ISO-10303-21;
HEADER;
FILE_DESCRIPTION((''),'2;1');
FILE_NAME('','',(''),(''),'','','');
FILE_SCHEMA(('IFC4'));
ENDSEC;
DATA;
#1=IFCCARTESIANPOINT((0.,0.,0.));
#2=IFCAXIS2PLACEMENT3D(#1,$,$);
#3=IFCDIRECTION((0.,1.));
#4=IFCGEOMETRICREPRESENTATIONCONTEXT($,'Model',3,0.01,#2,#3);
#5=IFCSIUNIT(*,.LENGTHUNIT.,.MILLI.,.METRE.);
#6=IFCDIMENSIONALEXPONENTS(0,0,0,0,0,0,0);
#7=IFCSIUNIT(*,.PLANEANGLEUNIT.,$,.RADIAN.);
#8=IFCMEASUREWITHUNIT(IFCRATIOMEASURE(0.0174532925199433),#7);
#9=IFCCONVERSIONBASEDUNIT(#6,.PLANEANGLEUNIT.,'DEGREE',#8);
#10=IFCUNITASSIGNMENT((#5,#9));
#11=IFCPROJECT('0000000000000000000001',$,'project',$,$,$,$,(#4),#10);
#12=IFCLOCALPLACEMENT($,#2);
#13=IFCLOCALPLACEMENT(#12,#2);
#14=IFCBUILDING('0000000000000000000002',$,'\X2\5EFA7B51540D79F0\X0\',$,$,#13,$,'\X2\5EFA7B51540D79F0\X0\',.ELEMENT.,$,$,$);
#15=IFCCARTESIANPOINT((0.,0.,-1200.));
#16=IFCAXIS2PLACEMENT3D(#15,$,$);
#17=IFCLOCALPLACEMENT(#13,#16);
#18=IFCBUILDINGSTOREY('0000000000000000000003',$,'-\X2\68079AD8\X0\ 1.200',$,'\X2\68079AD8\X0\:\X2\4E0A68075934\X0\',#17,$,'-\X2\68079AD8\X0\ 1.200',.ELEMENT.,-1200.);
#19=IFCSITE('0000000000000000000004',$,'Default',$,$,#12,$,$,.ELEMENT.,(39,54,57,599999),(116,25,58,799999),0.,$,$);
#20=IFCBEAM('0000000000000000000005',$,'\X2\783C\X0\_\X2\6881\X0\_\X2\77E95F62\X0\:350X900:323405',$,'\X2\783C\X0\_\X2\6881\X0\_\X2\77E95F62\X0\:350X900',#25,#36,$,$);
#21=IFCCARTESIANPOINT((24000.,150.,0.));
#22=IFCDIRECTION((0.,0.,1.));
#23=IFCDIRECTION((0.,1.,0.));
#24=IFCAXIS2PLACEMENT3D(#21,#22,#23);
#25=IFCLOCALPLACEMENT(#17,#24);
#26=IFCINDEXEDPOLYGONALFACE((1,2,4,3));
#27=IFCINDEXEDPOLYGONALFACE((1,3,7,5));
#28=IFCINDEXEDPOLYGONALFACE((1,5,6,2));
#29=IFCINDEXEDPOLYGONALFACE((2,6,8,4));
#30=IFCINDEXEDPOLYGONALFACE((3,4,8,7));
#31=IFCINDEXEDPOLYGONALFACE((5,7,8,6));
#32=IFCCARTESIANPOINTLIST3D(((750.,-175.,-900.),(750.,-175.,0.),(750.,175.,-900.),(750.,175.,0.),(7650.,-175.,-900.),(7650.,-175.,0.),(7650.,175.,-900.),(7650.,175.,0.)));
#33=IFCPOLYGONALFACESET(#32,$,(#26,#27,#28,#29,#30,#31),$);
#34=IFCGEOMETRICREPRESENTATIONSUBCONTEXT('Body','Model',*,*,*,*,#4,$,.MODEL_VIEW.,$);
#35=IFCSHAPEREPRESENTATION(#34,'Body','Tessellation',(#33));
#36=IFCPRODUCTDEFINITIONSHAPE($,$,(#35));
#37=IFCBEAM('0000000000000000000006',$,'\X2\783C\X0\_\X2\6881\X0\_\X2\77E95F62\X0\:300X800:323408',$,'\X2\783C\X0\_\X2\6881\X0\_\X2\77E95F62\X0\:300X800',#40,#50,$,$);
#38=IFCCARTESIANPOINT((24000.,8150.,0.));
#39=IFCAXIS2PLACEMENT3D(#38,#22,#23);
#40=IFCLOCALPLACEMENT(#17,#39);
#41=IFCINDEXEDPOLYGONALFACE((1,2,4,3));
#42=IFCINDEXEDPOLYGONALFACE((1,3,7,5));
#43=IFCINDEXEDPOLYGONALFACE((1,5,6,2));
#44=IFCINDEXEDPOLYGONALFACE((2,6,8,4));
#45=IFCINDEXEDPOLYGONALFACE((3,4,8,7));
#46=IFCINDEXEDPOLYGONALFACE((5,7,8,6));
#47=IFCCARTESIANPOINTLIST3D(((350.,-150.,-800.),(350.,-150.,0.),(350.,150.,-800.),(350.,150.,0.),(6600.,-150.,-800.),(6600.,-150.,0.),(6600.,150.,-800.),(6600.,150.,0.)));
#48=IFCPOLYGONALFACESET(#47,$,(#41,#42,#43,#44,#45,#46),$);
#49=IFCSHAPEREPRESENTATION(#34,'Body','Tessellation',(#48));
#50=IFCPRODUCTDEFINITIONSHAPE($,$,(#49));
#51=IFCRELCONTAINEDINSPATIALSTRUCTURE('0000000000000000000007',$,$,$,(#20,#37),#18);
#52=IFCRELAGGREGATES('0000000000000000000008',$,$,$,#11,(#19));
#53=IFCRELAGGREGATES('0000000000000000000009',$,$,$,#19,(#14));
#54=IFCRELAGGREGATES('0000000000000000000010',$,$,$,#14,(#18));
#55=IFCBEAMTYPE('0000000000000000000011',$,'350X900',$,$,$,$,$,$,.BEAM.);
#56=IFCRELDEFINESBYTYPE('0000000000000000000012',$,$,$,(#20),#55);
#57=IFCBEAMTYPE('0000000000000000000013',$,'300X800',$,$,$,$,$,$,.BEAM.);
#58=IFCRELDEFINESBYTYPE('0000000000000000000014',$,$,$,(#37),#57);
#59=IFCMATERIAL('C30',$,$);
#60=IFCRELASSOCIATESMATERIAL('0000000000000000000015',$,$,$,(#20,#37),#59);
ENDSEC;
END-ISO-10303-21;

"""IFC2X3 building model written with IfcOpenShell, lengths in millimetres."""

from ifc_helpers import new_model, entity, si_unit, converted_unit, direction, frame, frame_2d, origin, place, context, subcontext, project, spatial, rectangle, extrude, material, type_object, element, save


model = new_model("IFC2X3")

# Units and contexts
model_context = context("Model", 3, precision=0.01, world=origin(), true_north=direction((0.0, 1.0)))
body_context = subcontext(model_context, "Body", "Model", "MODEL_VIEW")
ifc_project = project(units=[si_unit("LENGTHUNIT", "METRE", prefix="MILLI"), converted_unit("PLANEANGLEUNIT", "DEGREE", entity("IfcRatioMeasure", 0.0174532925199433), si_unit("PLANEANGLEUNIT", "RADIAN"), dimensions=[0, 0, 0, 0, 0, 0, 0])], contexts=[model_context])

# Site, building, storey
site_placement = place(None, origin())
site = spatial("IfcSite", under=ifc_project, at=site_placement, Name="Default", CompositionType="ELEMENT", RefLatitude=(39, 54, 57, 599999), RefLongitude=(116, 25, 58, 799999), RefElevation=0.0)
building_placement = place(site_placement, origin())
building = spatial("IfcBuilding", under=site, at=building_placement, Name="建筑名称", LongName="建筑名称", CompositionType="ELEMENT")
storey_placement = place(building_placement, frame((0.0, 0.0, -1200.0)))
storey = spatial("IfcBuildingStorey", under=building, at=storey_placement, Name="-标高 1.200", ObjectType="标高:上标头", LongName="-标高 1.200", CompositionType="ELEMENT", Elevation=-1200.0)

# Beams
ifc_material_1 = material(Name="C30")
beam_type_1 = type_object("IfcBeamType", Name="350X900", PredefinedType="BEAM")
beam_1_placement = place(storey_placement, frame((24000.0, 150.0, 0.0), z_axis=(0.0, 0.0, 1.0), x_axis=(0.0, 1.0, 0.0)))
element("IfcBeam", 1, at=beam_1_placement, inside=storey, type_object=beam_type_1, material=ifc_material_1, Name="砼_梁_矩形:350X900:323405", ObjectType="砼_梁_矩形:350X900", context=body_context, shape_type="SweptSolid", body=[
    extrude(rectangle(XDim=900.0, YDim=350.0, at=frame_2d((0.0, 0.0), x_axis=(1.0, 0.0))), frame((750.0, 0.0, -450.0), z_axis=(1.0, 0.0, 0.0), x_axis=(0.0, 0.0, -1.0)), (0.0, 0.0, 1.0), 6900.0),
])
beam_type_2 = type_object("IfcBeamType", Name="300X800", PredefinedType="BEAM")
beam_2_placement = place(storey_placement, frame((24000.0, 8150.0, 0.0), z_axis=(0.0, 0.0, 1.0), x_axis=(0.0, 1.0, 0.0)))
element("IfcBeam", 2, at=beam_2_placement, inside=storey, type_object=beam_type_2, material=ifc_material_1, Name="砼_梁_矩形:300X800:323408", ObjectType="砼_梁_矩形:300X800", context=body_context, shape_type="SweptSolid", body=[
    extrude(rectangle(XDim=800.0, YDim=300.0, at=frame_2d((0.0, 0.0), x_axis=(1.0, 0.0))), frame((350.0, 0.0, -400.0), z_axis=(1.0, 0.0, 0.0), x_axis=(0.0, 0.0, -1.0)), (0.0, 0.0, 1.0), 6250.0),
])

save(model, "model.ifc")
